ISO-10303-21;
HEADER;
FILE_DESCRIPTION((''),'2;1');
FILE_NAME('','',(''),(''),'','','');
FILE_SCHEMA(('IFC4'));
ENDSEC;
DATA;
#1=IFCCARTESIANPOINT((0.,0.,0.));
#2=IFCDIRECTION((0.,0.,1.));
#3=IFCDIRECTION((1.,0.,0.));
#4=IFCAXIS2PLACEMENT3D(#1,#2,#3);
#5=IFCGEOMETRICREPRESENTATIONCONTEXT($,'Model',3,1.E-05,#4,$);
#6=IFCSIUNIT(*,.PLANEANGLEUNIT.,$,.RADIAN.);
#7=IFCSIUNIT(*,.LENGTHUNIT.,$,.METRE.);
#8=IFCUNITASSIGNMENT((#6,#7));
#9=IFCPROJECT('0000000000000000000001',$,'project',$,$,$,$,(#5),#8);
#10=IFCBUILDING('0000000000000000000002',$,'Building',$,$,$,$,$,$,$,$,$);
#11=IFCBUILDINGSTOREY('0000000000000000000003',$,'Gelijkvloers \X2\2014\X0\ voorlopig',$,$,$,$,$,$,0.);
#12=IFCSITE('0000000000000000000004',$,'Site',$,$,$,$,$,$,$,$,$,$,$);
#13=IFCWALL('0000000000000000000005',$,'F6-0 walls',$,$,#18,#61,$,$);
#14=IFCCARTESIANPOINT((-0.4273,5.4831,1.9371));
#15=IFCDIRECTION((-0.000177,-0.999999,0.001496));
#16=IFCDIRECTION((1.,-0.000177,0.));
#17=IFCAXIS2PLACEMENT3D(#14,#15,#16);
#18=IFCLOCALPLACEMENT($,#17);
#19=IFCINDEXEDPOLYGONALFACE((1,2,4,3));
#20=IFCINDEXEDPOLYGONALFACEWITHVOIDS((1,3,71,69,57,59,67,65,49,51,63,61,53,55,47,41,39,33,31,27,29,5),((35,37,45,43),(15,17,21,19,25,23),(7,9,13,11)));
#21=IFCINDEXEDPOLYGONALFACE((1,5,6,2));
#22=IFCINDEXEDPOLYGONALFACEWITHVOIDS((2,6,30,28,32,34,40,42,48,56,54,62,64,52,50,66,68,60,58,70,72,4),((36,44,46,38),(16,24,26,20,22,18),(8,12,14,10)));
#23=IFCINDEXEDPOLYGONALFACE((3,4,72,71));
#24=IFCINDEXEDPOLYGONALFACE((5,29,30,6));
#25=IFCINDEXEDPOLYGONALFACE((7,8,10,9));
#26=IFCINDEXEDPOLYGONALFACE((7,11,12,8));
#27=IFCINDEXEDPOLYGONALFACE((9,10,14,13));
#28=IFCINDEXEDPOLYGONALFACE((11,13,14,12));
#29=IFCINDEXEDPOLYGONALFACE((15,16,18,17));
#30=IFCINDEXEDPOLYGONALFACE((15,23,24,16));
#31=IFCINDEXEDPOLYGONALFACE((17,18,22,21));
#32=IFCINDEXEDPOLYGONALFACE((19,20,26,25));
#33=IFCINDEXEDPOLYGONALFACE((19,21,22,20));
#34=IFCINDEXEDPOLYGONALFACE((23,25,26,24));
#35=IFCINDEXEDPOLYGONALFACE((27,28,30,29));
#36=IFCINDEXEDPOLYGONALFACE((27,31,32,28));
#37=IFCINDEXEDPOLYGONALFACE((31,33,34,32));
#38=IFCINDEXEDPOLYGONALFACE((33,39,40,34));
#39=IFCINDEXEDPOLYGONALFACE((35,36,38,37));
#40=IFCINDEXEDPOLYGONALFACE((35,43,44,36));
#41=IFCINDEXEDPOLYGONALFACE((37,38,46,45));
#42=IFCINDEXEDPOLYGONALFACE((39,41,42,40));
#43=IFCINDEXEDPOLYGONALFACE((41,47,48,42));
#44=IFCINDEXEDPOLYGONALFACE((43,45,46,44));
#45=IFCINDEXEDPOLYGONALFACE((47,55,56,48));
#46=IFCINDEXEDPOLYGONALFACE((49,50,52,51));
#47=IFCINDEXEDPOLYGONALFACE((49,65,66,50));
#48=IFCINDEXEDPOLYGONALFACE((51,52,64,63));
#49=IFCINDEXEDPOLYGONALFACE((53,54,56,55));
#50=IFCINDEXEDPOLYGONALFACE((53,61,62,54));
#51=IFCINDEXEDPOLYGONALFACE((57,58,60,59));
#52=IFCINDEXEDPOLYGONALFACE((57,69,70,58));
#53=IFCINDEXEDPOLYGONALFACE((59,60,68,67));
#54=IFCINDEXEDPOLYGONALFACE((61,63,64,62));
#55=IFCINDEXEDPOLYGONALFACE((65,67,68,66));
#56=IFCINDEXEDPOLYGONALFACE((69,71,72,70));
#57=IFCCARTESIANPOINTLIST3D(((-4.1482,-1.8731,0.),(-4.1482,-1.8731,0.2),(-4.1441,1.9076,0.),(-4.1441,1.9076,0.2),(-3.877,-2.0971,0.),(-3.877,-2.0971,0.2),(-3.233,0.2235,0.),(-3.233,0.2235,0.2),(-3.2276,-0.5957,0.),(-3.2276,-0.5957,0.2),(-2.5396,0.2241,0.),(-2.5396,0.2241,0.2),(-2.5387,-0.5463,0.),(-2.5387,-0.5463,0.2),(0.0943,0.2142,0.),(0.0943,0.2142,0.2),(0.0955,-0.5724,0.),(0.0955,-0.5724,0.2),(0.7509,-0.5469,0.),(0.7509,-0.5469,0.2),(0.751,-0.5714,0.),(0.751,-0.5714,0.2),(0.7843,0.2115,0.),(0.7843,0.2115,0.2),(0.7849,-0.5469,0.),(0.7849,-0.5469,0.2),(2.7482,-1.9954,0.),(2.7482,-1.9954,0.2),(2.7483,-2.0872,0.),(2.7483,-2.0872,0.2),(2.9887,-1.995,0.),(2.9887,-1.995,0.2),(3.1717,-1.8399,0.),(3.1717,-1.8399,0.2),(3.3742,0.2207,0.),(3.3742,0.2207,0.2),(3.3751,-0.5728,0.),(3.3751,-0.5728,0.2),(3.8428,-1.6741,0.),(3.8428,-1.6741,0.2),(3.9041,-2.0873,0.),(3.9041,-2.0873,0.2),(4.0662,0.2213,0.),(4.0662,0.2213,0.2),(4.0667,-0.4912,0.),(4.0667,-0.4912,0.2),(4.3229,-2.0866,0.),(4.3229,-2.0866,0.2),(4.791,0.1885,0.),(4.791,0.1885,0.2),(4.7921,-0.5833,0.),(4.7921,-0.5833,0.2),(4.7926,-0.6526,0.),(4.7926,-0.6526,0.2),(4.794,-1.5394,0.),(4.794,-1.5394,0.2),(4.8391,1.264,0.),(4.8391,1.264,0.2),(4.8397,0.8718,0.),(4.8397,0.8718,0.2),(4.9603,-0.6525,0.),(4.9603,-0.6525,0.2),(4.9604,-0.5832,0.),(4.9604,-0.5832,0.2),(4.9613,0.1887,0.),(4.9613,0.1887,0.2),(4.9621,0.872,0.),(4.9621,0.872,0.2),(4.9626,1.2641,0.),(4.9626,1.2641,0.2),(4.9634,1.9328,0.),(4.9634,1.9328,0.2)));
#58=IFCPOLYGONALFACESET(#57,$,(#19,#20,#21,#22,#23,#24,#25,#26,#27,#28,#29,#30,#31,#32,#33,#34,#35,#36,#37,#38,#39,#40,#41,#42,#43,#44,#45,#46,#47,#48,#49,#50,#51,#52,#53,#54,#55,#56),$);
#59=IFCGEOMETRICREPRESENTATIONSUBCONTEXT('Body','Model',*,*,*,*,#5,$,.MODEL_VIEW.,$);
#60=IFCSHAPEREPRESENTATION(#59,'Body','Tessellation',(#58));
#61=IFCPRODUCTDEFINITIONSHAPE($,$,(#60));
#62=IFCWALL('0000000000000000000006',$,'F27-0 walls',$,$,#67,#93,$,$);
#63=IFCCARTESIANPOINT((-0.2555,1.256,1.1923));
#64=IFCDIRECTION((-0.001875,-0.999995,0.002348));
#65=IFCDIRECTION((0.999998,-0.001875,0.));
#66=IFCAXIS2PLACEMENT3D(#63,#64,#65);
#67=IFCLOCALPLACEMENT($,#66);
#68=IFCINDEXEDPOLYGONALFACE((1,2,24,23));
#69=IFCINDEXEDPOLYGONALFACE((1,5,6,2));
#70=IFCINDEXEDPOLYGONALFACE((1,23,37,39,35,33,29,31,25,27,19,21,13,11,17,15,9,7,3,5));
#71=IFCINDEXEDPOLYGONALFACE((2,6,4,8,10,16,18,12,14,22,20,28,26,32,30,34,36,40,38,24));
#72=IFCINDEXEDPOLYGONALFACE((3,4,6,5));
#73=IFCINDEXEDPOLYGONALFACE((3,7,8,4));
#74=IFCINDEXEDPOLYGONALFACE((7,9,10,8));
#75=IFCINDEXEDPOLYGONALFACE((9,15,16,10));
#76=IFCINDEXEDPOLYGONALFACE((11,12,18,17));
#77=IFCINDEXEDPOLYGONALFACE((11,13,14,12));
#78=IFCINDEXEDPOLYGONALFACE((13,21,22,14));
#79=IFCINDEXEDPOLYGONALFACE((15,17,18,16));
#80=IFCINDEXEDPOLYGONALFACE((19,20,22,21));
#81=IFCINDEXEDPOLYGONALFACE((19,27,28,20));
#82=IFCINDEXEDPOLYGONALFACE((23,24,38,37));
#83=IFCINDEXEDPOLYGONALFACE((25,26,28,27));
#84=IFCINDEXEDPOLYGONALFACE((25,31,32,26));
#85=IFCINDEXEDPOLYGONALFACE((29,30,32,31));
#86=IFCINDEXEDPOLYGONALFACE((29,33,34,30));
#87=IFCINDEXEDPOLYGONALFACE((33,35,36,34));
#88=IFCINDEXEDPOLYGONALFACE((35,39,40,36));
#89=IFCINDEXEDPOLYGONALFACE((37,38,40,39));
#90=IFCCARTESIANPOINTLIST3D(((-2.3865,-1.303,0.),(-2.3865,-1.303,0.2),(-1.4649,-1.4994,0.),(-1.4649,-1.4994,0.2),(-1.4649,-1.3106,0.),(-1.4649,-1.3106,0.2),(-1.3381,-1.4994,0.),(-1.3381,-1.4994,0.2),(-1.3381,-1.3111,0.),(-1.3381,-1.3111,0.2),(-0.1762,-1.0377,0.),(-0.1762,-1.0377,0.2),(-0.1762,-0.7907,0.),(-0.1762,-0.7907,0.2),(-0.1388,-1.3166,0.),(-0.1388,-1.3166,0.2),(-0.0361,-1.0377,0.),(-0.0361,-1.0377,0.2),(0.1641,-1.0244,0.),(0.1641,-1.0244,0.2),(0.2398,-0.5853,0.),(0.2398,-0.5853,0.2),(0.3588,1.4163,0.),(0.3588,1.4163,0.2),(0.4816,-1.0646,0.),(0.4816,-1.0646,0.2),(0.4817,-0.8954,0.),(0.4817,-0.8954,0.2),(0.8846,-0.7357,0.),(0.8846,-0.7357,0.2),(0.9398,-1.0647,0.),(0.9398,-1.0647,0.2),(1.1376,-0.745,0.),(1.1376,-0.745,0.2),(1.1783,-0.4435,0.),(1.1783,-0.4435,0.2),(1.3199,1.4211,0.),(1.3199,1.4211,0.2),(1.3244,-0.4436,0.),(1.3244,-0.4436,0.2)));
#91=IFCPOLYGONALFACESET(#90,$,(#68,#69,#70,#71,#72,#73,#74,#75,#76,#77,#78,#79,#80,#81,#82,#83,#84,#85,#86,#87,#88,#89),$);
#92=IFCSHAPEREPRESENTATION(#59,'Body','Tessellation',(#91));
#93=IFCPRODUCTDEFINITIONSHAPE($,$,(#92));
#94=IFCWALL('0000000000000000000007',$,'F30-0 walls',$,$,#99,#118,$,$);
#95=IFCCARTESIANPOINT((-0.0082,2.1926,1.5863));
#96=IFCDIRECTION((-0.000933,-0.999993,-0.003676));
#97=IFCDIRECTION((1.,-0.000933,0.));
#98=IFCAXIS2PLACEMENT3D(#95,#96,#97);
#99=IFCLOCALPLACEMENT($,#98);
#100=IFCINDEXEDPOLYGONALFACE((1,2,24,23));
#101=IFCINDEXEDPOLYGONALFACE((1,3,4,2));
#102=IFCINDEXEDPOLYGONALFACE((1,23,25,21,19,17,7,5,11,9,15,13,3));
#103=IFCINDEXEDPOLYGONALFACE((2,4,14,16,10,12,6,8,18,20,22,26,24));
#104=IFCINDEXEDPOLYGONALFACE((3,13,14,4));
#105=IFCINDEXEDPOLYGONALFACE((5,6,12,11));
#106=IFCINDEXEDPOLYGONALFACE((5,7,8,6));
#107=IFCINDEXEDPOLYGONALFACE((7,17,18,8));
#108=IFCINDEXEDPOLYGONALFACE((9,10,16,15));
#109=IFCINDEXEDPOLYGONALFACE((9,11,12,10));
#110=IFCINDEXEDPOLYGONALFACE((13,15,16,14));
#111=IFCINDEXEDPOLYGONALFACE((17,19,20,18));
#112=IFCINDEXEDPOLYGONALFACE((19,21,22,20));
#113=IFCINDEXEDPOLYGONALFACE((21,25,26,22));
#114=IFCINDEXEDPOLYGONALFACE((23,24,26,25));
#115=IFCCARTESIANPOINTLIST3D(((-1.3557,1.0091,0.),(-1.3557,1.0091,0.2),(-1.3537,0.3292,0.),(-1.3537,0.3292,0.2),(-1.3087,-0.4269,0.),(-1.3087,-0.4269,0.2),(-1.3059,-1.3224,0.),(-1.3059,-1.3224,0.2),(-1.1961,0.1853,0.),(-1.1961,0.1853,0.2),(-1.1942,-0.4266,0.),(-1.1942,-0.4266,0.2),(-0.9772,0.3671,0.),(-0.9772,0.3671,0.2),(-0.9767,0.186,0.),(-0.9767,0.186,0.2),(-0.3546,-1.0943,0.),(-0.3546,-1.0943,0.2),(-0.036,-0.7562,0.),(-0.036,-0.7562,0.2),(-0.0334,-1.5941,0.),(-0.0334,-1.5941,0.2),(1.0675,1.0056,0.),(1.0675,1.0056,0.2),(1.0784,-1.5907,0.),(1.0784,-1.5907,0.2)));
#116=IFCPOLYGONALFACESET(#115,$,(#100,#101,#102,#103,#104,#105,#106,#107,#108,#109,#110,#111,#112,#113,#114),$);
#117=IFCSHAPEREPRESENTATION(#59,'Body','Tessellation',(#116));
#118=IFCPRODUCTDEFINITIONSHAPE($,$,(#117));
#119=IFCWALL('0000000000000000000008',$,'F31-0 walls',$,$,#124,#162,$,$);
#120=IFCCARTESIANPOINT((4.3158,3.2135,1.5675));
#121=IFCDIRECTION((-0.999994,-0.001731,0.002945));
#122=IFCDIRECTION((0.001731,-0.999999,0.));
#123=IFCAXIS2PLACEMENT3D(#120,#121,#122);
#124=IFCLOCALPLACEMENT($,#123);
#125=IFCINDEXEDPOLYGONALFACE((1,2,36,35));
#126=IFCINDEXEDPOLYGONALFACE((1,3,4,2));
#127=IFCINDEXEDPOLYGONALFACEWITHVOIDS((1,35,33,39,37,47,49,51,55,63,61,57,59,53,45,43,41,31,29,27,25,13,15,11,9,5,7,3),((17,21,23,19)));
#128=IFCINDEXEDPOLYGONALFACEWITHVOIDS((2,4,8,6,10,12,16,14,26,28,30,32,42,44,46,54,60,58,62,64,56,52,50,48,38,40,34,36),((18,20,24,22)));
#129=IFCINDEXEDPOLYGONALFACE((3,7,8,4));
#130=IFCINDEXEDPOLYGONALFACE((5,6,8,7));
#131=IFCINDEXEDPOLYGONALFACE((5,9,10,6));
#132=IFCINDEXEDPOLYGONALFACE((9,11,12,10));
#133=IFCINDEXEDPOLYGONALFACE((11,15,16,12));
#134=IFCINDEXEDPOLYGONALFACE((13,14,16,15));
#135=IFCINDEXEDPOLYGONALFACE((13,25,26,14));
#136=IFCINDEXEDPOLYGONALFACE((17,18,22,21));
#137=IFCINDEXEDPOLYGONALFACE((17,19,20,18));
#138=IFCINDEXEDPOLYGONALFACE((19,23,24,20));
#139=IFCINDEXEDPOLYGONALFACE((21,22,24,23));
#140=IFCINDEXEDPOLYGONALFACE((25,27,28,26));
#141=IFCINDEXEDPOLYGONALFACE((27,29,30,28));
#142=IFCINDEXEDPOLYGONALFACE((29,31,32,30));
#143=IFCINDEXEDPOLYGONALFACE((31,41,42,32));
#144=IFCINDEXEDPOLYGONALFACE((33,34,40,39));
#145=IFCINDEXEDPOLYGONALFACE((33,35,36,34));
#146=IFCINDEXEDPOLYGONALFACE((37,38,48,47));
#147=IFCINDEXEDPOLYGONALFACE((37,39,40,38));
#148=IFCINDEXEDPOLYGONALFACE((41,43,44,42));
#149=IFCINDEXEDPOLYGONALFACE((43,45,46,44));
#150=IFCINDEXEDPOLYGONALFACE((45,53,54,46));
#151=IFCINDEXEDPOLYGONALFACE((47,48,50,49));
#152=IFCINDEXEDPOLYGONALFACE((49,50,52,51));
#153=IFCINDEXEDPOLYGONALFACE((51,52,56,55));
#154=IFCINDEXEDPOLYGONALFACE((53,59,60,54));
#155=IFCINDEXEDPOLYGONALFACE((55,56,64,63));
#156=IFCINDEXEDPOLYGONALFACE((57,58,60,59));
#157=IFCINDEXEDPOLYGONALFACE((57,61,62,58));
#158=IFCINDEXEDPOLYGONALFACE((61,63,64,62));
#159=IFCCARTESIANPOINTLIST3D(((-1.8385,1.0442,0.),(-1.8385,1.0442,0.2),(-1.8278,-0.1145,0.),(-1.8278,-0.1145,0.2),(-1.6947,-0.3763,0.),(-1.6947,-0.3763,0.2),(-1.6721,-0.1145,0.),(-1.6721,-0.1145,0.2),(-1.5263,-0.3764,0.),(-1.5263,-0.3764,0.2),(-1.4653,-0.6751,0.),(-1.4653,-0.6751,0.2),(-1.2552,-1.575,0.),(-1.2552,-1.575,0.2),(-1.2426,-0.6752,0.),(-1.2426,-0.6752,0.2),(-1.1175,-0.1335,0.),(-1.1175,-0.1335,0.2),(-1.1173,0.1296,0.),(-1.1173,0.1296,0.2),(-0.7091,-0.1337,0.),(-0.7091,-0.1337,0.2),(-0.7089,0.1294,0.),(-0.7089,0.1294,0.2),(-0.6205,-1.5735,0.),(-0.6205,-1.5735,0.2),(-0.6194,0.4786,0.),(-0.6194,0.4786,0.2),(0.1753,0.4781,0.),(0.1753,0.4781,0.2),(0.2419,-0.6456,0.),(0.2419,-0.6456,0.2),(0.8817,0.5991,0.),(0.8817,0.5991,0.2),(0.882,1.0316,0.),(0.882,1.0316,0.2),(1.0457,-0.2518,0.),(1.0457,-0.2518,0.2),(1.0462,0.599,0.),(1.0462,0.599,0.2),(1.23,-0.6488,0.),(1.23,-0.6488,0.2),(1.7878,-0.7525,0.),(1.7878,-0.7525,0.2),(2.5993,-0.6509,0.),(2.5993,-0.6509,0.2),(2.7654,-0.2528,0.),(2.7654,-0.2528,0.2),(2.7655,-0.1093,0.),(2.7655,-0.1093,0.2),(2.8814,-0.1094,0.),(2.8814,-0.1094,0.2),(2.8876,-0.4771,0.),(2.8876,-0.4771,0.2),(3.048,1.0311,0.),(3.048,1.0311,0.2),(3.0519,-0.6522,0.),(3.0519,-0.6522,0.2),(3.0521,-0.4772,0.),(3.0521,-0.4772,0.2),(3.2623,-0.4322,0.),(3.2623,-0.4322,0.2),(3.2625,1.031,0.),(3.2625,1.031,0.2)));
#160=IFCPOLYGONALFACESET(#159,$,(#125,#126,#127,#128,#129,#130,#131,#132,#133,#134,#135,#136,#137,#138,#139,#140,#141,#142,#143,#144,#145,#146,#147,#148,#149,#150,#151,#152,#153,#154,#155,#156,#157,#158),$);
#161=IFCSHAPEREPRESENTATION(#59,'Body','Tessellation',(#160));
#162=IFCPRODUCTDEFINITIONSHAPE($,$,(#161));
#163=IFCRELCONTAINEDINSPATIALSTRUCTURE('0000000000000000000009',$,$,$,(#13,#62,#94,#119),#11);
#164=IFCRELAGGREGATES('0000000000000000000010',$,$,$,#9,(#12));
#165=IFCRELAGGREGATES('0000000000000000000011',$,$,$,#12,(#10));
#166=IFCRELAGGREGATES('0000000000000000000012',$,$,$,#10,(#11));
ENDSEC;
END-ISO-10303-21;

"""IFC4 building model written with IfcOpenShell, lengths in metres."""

from ifc_helpers import new_model, si_unit, frame, origin_with_axes, place, context, subcontext, project, spatial, polyline, outline, extrude, element, save


model = new_model("IFC4")

# Units and contexts
model_context = context("Model", 3, precision=1e-05, world=origin_with_axes())
body_context = subcontext(model_context, "Body", "Model", "MODEL_VIEW")
ifc_project = project(units=[si_unit("PLANEANGLEUNIT", "RADIAN"), si_unit("LENGTHUNIT", "METRE")], contexts=[model_context])

# Site, building, storey
site = spatial("IfcSite", under=ifc_project, Name="Site")
building = spatial("IfcBuilding", under=site, Name="Building")
storey = spatial("IfcBuildingStorey", under=building, Name="Gelijkvloers — voorlopig", Elevation=0.0)

# Wall, openings
wall_1_placement = place(None, frame((-0.4273, 5.4831, 1.9371), z_axis=(-0.000177, -0.999999, 0.001496), x_axis=(1.0, -0.000177, 0.0)))
wall_1 = element("IfcWall", 1, at=wall_1_placement, inside=storey, Name="F6-0 walls", context=body_context, shape_type="SweptSolid", body=[
    extrude(outline(polyline([(-3.877, -2.0971), (2.7483, -2.0872), (2.7482, -1.9954), (2.9887, -1.995), (3.1717, -1.8399), (3.8428, -1.6741), (3.9041, -2.0873), (4.3229, -2.0866), (4.794, -1.5394), (4.7926, -0.6526), (4.9603, -0.6525), (4.9604, -0.5832), (4.7921, -0.5833), (4.791, 0.1885), (4.9613, 0.1887), (4.9621, 0.872), (4.8397, 0.8718), (4.8391, 1.264), (4.9626, 1.2641), (4.9634, 1.9328), (-4.1441, 1.9076), (-4.1482, -1.8731), (-3.877, -2.0971)])), origin_with_axes(), (0.0, 0.0, 1.0), 0.2),
])
opening_1_placement = place(wall_1_placement, frame((0.0, 0.0, -0.05), z_axis=(0.0, 0.0, 1.0), x_axis=(1.0, 0.0, 0.0)))
element("IfcOpeningElement", 2, at=opening_1_placement, cuts=wall_1, PredefinedType="OPENING", context=body_context, shape_type="SweptSolid", body=[
    extrude(outline(polyline([(-2.5396, 0.2241), (-2.5387, -0.5463), (-3.2276, -0.5957), (-3.233, 0.2235), (-2.5396, 0.2241)])), origin_with_axes(), (0.0, 0.0, 1.0), 0.3),
])
opening_2_placement = place(wall_1_placement, frame((0.0, 0.0, -0.05), z_axis=(0.0, 0.0, 1.0), x_axis=(1.0, 0.0, 0.0)))
element("IfcOpeningElement", 3, at=opening_2_placement, cuts=wall_1, PredefinedType="OPENING", context=body_context, shape_type="SweptSolid", body=[
    extrude(outline(polyline([(3.3751, -0.5728), (3.3742, 0.2207), (4.0662, 0.2213), (4.0667, -0.4912), (3.3751, -0.5728)])), origin_with_axes(), (0.0, 0.0, 1.0), 0.3),
])
opening_3_placement = place(wall_1_placement, frame((0.0, 0.0, -0.05), z_axis=(0.0, 0.0, 1.0), x_axis=(1.0, 0.0, 0.0)))
element("IfcOpeningElement", 4, at=opening_3_placement, cuts=wall_1, PredefinedType="OPENING", context=body_context, shape_type="SweptSolid", body=[
    extrude(outline(polyline([(0.0943, 0.2142), (0.7843, 0.2115), (0.7849, -0.5469), (0.7509, -0.5469), (0.751, -0.5714), (0.0955, -0.5724), (0.0943, 0.2142)])), origin_with_axes(), (0.0, 0.0, 1.0), 0.3),
])

# Walls
wall_2_placement = place(None, frame((-0.2555, 1.256, 1.1923), z_axis=(-0.001875, -0.999995, 0.002348), x_axis=(0.999998, -0.001875, 0.0)))
element("IfcWall", 5, at=wall_2_placement, inside=storey, Name="F27-0 walls", context=body_context, shape_type="SweptSolid", body=[
    extrude(outline(polyline([(-1.4649, -1.4994), (-1.3381, -1.4994), (-1.3381, -1.3111), (-0.1388, -1.3166), (-0.0361, -1.0377), (-0.1762, -1.0377), (-0.1762, -0.7907), (0.2398, -0.5853), (0.1641, -1.0244), (0.4817, -0.8954), (0.4816, -1.0646), (0.9398, -1.0647), (0.8846, -0.7357), (1.1376, -0.745), (1.1783, -0.4435), (1.3244, -0.4436), (1.3199, 1.4211), (0.3588, 1.4163), (-2.3865, -1.303), (-1.4649, -1.3106), (-1.4649, -1.4994)])), origin_with_axes(), (0.0, 0.0, 1.0), 0.2),
])
wall_3_placement = place(None, frame((-0.0082, 2.1926, 1.5863), z_axis=(-0.000933, -0.999993, -0.003676), x_axis=(1.0, -0.000933, 0.0)))
element("IfcWall", 6, at=wall_3_placement, inside=storey, Name="F30-0 walls", context=body_context, shape_type="SweptSolid", body=[
    extrude(outline(polyline([(-0.0334, -1.5941), (1.0784, -1.5907), (1.0675, 1.0056), (-1.3557, 1.0091), (-1.3537, 0.3292), (-0.9772, 0.3671), (-0.9767, 0.186), (-1.1961, 0.1853), (-1.1942, -0.4266), (-1.3087, -0.4269), (-1.3059, -1.3224), (-0.3546, -1.0943), (-0.036, -0.7562), (-0.0334, -1.5941)])), origin_with_axes(), (0.0, 0.0, 1.0), 0.2),
])

# Wall, opening
wall_4_placement = place(None, frame((4.3158, 3.2135, 1.5675), z_axis=(-0.999994, -0.001731, 0.002945), x_axis=(0.001731, -0.999999, 0.0)))
wall_4 = element("IfcWall", 7, at=wall_4_placement, inside=storey, Name="F31-0 walls", context=body_context, shape_type="SweptSolid", body=[
    extrude(outline(polyline([(-1.2552, -1.575), (-0.6205, -1.5735), (-0.6194, 0.4786), (0.1753, 0.4781), (0.2419, -0.6456), (1.23, -0.6488), (1.7878, -0.7525), (2.5993, -0.6509), (2.8876, -0.4771), (3.0521, -0.4772), (3.0519, -0.6522), (3.2623, -0.4322), (3.2625, 1.031), (3.048, 1.0311), (2.8814, -0.1094), (2.7655, -0.1093), (2.7654, -0.2528), (1.0457, -0.2518), (1.0462, 0.599), (0.8817, 0.5991), (0.882, 1.0316), (-1.8385, 1.0442), (-1.8278, -0.1145), (-1.6721, -0.1145), (-1.6947, -0.3763), (-1.5263, -0.3764), (-1.4653, -0.6751), (-1.2426, -0.6752), (-1.2552, -1.575)])), origin_with_axes(), (0.0, 0.0, 1.0), 0.2),
])
opening_4_placement = place(wall_4_placement, frame((0.0, 0.0, -0.05), z_axis=(0.0, 0.0, 1.0), x_axis=(1.0, 0.0, 0.0)))
element("IfcOpeningElement", 8, at=opening_4_placement, cuts=wall_4, PredefinedType="OPENING", context=body_context, shape_type="SweptSolid", body=[
    extrude(outline(polyline([(-1.1175, -0.1335), (-1.1173, 0.1296), (-0.7089, 0.1294), (-0.7091, -0.1337), (-1.1175, -0.1335)])), origin_with_axes(), (0.0, 0.0, 1.0), 0.3),
])

save(model, "model.ifc")
